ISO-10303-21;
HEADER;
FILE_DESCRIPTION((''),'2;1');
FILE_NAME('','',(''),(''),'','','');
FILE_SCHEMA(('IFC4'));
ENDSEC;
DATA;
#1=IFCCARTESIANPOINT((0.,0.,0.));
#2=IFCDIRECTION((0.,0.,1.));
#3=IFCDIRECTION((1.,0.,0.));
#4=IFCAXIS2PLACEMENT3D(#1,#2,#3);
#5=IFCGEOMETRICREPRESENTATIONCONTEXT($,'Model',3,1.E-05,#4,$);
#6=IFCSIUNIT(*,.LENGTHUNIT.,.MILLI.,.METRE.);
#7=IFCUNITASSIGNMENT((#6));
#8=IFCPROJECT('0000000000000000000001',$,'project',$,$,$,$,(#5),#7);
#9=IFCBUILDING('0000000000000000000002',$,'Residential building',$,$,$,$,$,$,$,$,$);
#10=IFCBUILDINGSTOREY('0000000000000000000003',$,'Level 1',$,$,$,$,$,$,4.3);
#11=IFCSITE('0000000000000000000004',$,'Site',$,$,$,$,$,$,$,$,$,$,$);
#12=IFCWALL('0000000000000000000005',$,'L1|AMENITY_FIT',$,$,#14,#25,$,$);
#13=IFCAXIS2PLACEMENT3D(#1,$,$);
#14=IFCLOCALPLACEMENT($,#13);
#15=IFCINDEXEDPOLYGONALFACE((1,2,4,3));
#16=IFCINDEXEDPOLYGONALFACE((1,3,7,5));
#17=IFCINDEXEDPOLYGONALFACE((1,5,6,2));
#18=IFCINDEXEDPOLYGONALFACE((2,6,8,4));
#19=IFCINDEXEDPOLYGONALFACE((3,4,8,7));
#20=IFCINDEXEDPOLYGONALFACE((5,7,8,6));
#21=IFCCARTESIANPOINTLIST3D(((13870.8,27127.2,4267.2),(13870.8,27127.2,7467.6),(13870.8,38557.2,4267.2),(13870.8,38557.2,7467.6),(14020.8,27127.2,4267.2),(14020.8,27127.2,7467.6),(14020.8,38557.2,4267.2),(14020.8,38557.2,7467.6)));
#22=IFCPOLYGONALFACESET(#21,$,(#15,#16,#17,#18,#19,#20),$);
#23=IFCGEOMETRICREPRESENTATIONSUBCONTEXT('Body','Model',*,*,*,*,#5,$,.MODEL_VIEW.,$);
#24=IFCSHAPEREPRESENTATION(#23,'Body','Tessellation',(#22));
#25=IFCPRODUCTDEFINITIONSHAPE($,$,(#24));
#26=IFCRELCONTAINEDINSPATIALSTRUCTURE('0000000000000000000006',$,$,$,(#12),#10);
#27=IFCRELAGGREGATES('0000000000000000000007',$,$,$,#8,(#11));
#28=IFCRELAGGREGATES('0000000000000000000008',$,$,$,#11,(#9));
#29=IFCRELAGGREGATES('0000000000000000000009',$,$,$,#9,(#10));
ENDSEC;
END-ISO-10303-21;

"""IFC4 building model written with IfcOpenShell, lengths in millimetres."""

from ifc_helpers import new_model, si_unit, frame, origin_with_axes, place, context, subcontext, project, spatial, indexed_curve, outline, extrude, element, save


model = new_model("IFC4")

# Units and contexts
model_context = context("Model", 3, precision=1e-05, world=origin_with_axes())
body_context = subcontext(model_context, "Body", "Model", "MODEL_VIEW")
ifc_project = project(units=[si_unit("LENGTHUNIT", "METRE", prefix="MILLI")], contexts=[model_context])

# Site, building, storey
site = spatial("IfcSite", under=ifc_project, Name="Site")
building = spatial("IfcBuilding", under=site, Name="Residential building")
storey = spatial("IfcBuildingStorey", under=building, Name="Level 1", Elevation=4.3)

# Wall
for number, where, z_axis, x_axis, name in (
    (1, (14020.8, 27127.2, 4267.2), (0.0, 0.0, 1.0), (0.0, 1.0, 0.0), "L1|AMENITY_FIT"),
):
    element("IfcWall", number, at=place(None, frame(where, z_axis=z_axis, x_axis=x_axis)), inside=storey, Name=name, context=body_context, shape_type="SweptSolid", body=[
        extrude(outline(indexed_curve([(0.0, 0.0), (0.0, 150.0), (11430.0, 150.0), (11430.0, 0.0), (0.0, 0.0)], self_intersect=False)), origin_with_axes(), (0.0, 0.0, 1.0), 3200.4),
    ])

save(model, "model.ifc")
